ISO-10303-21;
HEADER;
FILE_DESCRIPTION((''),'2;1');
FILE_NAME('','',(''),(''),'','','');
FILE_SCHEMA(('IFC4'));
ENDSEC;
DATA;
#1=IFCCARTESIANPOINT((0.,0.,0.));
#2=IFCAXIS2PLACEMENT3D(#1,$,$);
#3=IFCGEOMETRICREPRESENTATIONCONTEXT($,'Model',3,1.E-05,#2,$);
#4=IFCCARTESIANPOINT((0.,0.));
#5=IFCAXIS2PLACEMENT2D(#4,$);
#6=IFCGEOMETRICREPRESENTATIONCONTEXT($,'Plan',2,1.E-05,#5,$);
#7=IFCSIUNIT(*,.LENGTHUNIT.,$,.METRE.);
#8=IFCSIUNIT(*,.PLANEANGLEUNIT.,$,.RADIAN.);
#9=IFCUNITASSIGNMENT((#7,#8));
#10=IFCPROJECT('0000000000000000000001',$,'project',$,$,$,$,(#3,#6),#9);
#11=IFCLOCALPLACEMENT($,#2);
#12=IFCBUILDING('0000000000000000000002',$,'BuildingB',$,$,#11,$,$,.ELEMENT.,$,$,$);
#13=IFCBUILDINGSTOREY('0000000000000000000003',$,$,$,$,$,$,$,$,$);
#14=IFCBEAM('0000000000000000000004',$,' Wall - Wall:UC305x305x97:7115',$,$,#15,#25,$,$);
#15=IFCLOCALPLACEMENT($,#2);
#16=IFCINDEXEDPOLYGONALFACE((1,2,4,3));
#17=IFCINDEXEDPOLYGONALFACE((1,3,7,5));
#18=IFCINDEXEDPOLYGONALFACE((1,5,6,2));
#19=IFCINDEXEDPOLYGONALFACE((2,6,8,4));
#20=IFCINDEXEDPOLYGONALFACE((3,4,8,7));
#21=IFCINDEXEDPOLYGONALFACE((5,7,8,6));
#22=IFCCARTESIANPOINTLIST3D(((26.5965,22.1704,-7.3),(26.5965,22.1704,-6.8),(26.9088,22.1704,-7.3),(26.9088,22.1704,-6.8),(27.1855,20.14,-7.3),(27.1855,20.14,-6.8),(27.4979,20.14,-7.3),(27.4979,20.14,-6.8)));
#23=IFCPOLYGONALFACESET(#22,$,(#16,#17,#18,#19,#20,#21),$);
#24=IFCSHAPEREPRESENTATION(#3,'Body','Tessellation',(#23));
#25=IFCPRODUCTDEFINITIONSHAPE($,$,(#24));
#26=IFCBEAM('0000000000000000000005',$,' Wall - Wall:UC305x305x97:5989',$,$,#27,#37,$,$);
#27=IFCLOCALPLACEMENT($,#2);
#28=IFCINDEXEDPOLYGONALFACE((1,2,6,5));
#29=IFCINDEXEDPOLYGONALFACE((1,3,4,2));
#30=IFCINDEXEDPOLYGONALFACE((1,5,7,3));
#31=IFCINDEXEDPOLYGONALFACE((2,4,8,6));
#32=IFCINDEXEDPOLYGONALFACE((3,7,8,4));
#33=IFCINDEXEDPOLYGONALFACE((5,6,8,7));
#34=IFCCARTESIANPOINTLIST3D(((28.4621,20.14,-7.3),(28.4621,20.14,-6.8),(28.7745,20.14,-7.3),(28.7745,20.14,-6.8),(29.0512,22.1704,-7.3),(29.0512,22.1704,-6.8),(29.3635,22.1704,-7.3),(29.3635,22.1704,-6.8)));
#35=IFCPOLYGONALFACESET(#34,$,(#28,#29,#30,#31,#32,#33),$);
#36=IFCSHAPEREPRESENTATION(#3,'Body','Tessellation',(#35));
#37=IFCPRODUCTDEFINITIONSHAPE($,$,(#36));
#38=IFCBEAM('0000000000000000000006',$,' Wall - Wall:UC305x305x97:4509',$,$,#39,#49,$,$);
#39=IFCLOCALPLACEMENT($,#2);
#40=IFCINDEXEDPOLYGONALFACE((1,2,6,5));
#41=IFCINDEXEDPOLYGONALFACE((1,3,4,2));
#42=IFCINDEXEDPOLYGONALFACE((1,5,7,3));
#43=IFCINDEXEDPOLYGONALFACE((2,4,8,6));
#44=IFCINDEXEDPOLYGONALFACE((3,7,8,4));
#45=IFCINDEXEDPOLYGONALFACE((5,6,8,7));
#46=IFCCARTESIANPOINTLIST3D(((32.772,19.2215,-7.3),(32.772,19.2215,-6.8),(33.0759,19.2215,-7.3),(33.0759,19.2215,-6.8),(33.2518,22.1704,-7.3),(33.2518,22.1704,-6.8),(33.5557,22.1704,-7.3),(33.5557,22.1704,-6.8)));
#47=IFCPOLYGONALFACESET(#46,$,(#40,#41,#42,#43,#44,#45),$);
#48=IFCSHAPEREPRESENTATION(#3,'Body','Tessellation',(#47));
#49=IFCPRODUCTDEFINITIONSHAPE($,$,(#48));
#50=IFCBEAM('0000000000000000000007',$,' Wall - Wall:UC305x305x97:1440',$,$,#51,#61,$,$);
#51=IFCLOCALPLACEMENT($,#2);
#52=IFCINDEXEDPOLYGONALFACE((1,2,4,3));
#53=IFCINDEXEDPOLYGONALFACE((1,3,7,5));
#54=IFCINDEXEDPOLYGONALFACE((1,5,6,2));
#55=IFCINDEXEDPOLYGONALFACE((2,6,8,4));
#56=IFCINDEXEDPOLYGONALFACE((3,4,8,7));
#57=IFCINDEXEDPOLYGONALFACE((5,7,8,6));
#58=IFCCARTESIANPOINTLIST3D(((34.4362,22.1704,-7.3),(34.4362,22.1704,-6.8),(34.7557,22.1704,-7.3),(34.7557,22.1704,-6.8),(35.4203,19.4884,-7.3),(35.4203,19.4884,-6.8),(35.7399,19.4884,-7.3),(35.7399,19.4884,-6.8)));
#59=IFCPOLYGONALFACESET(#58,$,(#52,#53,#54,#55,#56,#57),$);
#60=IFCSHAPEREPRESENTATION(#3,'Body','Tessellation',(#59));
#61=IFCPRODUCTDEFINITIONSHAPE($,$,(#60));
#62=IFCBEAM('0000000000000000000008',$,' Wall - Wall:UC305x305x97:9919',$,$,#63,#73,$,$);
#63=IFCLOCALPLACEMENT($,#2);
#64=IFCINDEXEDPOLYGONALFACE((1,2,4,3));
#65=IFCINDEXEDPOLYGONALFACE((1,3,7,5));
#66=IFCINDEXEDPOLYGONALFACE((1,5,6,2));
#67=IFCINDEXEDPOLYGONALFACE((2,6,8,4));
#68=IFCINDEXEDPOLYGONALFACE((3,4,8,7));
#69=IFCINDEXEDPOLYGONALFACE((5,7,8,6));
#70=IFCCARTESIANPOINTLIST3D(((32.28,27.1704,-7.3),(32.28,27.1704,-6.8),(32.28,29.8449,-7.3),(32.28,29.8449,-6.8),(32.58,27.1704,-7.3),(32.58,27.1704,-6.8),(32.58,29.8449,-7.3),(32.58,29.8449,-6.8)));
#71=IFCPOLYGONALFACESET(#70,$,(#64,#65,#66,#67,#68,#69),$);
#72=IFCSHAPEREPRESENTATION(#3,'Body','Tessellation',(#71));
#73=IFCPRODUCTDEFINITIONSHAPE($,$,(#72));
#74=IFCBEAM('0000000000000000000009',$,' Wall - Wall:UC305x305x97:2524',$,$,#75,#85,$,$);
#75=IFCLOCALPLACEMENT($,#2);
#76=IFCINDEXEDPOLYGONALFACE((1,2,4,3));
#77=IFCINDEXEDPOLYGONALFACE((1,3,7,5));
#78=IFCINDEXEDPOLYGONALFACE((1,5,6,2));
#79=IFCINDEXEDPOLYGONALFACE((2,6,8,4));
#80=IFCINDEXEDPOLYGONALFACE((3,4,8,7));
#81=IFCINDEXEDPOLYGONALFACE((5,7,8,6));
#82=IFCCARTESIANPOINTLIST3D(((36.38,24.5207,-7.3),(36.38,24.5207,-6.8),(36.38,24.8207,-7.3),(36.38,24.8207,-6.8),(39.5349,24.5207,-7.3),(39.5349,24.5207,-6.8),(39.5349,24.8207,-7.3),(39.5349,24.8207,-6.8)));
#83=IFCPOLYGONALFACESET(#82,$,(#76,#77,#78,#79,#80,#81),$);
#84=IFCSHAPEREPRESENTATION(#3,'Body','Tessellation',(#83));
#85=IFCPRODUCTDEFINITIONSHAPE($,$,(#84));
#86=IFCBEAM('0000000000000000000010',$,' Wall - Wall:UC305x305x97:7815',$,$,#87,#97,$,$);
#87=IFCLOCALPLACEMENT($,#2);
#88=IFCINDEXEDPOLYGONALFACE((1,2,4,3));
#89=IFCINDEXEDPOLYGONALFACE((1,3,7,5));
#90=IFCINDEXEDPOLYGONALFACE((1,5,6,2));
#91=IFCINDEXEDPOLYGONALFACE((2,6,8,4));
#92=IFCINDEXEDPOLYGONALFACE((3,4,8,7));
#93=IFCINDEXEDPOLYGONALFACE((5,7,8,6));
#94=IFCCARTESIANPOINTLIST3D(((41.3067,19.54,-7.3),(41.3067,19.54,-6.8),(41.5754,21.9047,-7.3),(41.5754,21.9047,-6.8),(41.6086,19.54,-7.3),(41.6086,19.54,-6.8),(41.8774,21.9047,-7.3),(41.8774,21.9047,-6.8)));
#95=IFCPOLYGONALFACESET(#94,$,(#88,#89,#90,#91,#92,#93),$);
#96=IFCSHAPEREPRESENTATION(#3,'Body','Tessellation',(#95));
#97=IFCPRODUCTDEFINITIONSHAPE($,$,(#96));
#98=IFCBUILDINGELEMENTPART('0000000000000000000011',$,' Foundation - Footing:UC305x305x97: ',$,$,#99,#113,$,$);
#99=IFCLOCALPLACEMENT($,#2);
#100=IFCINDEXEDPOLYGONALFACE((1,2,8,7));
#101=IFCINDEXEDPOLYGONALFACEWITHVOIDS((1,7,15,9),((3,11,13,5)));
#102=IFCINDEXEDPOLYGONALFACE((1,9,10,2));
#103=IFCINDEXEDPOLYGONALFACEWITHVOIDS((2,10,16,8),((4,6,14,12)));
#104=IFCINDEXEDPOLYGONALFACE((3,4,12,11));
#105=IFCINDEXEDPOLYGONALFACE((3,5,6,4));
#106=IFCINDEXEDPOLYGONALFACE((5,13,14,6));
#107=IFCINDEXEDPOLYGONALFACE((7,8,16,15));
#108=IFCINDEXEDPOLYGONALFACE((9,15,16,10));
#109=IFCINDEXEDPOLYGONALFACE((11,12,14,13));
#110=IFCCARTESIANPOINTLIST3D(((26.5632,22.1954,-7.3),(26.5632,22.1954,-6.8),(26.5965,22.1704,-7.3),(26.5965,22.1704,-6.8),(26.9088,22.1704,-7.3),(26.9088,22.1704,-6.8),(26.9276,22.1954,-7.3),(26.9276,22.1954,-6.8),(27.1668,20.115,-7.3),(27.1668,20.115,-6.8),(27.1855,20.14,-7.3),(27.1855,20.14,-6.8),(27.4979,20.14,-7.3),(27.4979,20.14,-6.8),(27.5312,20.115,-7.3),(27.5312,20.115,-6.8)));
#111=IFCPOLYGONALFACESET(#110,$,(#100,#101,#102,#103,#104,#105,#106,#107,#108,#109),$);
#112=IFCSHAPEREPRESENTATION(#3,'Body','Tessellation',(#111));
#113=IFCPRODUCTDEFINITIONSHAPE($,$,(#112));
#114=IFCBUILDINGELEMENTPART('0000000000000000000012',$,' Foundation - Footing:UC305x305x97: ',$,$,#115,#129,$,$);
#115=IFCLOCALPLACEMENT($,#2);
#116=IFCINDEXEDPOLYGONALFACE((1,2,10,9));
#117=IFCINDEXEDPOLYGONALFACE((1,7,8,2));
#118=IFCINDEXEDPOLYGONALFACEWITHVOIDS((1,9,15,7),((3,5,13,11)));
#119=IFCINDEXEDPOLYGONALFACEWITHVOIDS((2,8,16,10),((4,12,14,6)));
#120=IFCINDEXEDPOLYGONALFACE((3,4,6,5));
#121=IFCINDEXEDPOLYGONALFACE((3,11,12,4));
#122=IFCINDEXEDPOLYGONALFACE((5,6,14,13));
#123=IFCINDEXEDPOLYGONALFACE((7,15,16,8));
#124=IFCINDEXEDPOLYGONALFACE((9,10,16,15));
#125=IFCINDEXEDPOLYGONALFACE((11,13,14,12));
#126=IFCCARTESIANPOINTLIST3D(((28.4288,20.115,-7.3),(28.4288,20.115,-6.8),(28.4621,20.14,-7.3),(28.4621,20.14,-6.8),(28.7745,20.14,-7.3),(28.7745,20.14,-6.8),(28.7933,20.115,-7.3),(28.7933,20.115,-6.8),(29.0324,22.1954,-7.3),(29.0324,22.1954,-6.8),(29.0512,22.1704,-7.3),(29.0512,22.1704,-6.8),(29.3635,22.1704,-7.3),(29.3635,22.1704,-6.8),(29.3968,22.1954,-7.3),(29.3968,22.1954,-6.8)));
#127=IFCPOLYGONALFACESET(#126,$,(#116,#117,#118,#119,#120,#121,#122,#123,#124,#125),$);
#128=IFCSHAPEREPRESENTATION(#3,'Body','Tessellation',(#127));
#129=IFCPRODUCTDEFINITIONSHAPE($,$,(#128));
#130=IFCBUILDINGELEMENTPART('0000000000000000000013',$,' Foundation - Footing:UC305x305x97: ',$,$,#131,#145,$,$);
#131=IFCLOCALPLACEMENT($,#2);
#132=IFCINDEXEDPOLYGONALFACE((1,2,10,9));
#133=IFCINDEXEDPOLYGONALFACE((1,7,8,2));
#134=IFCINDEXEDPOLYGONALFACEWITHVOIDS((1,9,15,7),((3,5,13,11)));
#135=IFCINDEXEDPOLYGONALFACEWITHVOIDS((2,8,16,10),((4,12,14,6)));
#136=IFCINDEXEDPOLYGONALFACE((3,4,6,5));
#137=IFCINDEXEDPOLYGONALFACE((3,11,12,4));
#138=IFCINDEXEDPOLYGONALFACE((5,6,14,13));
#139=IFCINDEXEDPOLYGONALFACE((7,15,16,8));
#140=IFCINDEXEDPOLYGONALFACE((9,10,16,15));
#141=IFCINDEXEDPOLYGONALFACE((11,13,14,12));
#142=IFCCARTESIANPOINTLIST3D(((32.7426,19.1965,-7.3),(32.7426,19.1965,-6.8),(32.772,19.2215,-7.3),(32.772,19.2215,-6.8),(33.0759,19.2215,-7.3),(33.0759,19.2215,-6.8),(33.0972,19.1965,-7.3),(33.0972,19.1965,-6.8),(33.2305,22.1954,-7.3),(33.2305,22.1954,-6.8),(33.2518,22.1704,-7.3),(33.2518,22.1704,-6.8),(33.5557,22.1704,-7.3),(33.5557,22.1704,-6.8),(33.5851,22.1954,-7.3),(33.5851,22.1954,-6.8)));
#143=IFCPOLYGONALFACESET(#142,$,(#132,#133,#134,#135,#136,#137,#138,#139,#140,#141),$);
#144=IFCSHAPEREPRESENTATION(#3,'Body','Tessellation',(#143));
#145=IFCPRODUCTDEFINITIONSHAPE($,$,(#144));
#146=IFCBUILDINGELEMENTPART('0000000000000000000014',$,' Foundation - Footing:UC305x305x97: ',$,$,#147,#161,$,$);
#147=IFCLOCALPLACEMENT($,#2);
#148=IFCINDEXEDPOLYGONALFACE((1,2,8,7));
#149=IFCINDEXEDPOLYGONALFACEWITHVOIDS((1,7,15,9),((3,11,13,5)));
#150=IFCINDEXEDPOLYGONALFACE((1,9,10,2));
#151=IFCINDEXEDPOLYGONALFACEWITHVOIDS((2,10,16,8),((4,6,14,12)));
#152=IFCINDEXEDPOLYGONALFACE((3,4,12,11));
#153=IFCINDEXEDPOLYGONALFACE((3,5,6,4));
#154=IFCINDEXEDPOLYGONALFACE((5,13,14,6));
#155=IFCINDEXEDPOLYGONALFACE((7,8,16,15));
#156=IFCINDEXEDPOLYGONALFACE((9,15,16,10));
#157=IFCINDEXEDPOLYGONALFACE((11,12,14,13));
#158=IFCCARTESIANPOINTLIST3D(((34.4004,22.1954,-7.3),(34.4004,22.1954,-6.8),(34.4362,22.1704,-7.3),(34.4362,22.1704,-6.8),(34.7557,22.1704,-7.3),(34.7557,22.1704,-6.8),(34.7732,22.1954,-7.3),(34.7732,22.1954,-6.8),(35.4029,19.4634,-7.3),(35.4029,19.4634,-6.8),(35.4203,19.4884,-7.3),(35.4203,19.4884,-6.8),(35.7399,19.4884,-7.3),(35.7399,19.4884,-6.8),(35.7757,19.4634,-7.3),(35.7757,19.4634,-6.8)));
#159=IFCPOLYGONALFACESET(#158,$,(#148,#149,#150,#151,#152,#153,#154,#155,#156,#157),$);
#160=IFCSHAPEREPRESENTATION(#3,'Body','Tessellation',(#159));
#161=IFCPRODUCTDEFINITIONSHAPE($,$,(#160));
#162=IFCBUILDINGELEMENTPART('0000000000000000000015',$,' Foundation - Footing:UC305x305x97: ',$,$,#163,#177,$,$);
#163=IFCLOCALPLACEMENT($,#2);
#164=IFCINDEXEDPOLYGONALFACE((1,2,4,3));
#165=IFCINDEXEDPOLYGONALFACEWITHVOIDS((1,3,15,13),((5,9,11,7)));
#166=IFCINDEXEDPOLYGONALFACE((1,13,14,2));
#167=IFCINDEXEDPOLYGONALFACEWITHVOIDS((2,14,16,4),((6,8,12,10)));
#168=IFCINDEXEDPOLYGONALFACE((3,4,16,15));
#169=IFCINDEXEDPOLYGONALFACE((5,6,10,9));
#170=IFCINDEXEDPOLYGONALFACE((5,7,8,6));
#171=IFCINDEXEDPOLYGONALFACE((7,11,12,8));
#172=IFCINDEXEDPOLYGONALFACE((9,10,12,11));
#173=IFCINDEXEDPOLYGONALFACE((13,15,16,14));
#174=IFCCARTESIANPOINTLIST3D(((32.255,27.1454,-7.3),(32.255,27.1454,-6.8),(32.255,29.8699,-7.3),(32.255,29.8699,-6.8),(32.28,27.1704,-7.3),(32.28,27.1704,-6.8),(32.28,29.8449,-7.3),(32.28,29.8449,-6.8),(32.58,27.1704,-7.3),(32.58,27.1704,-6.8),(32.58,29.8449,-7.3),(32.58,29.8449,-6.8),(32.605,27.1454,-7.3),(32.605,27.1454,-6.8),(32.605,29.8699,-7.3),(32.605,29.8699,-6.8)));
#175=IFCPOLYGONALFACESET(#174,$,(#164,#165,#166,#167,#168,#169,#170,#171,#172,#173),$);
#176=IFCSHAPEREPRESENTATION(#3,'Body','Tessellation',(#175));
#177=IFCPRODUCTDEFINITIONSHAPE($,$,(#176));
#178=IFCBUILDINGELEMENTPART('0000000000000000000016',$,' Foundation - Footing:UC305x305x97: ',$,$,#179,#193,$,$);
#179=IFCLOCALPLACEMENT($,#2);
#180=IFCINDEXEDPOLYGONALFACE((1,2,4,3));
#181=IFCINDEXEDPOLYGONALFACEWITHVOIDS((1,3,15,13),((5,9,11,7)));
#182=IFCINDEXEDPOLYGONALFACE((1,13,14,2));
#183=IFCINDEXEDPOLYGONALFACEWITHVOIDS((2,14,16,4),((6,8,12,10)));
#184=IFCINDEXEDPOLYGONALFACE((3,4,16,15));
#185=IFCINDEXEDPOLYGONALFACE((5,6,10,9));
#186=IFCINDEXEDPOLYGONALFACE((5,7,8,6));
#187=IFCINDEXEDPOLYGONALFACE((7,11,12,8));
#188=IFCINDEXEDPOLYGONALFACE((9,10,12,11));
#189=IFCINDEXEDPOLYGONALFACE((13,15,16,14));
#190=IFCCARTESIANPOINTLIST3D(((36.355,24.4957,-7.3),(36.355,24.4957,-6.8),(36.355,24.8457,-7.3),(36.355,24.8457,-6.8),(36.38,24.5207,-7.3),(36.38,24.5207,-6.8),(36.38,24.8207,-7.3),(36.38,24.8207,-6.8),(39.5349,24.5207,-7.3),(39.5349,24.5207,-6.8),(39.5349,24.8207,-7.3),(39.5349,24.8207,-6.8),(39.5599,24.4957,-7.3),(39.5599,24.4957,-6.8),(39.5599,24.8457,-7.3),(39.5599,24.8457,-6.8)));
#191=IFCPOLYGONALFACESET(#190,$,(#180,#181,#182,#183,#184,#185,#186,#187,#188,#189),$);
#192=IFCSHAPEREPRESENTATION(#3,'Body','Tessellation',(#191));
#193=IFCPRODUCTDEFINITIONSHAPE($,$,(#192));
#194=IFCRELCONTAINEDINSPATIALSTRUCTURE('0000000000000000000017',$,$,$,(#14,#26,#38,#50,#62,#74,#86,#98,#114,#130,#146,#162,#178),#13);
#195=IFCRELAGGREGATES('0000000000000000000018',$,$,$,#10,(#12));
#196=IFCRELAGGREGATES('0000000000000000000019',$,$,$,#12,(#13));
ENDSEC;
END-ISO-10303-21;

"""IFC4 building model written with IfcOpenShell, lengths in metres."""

from ifc_helpers import new_model, si_unit, origin, origin_2d, place, context, project, spatial, polyline, outline, extrude, element, save


model = new_model("IFC4")

# Units and contexts
model_context = context("Model", 3, precision=1e-05, world=origin())
plan_context = context("Plan", 2, precision=1e-05, world=origin_2d())
ifc_project = project(units=[si_unit("LENGTHUNIT", "METRE"), si_unit("PLANEANGLEUNIT", "RADIAN")], contexts=[model_context, plan_context])

# Building, storey
building_placement = place(None, origin())
building = spatial("IfcBuilding", under=ifc_project, at=building_placement, Name="BuildingB", CompositionType="ELEMENT")
storey = spatial("IfcBuildingStorey", under=building)

# Beams
element("IfcBeam", 1, inside=storey, Name=" Wall - Wall:UC305x305x97:7115", context=model_context, shape_type="SweptSolid", body=[
    extrude(outline(polyline([(27.1855, 20.14, -7.3), (27.4979, 20.14, -7.3), (26.9088, 22.1704, -7.3), (26.5965, 22.1704, -7.3), (27.1855, 20.14, -7.3)])), None, (0.0, 0.0, 1.0), 0.5),
])
element("IfcBeam", 2, inside=storey, Name=" Wall - Wall:UC305x305x97:5989", context=model_context, shape_type="SweptSolid", body=[
    extrude(outline(polyline([(28.4621, 20.14, -7.3), (29.0512, 22.1704, -7.3), (29.3635, 22.1704, -7.3), (28.7745, 20.14, -7.3), (28.4621, 20.14, -7.3)])), None, (0.0, 0.0, 1.0), 0.5),
])
element("IfcBeam", 3, inside=storey, Name=" Wall - Wall:UC305x305x97:4509", context=model_context, shape_type="SweptSolid", body=[
    extrude(outline(polyline([(32.772, 19.2215, -7.3), (33.0759, 19.2215, -7.3), (33.5557, 22.1704, -7.3), (33.2518, 22.1704, -7.3), (32.772, 19.2215, -7.3)])), None, (0.0, 0.0, 1.0), 0.5),
])
element("IfcBeam", 4, inside=storey, Name=" Wall - Wall:UC305x305x97:1440", context=model_context, shape_type="SweptSolid", body=[
    extrude(outline(polyline([(35.4203, 19.4884, -7.3), (35.7399, 19.4884, -7.3), (34.7557, 22.1704, -7.3), (34.4362, 22.1704, -7.3), (35.4203, 19.4884, -7.3)])), None, (0.0, 0.0, 1.0), 0.5),
])
element("IfcBeam", 5, inside=storey, Name=" Wall - Wall:UC305x305x97:9919", context=model_context, shape_type="SweptSolid", body=[
    extrude(outline(polyline([(32.28, 27.1704, -7.3), (32.58, 27.1704, -7.3), (32.58, 29.8449, -7.3), (32.28, 29.8449, -7.3), (32.28, 27.1704, -7.3)])), None, (0.0, 0.0, 1.0), 0.5),
])
element("IfcBeam", 6, inside=storey, Name=" Wall - Wall:UC305x305x97:2524", context=model_context, shape_type="SweptSolid", body=[
    extrude(outline(polyline([(36.38, 24.5207, -7.3), (36.38, 24.8207, -7.3), (39.5349, 24.8207, -7.3), (39.5349, 24.5207, -7.3), (36.38, 24.5207, -7.3)])), None, (0.0, 0.0, 1.0), 0.5),
])
element("IfcBeam", 7, inside=storey, Name=" Wall - Wall:UC305x305x97:7815", context=model_context, shape_type="SweptSolid", body=[
    extrude(outline(polyline([(41.3067, 19.54, -7.3), (41.6086, 19.54, -7.3), (41.8774, 21.9047, -7.3), (41.5754, 21.9047, -7.3), (41.3067, 19.54, -7.3)])), None, (0.0, 0.0, 1.0), 0.5),
])

# Building element parts, openings
building_element_part_1 = element("IfcBuildingElementPart", 8, inside=storey, Name=" Foundation - Footing:UC305x305x97: ", context=model_context, shape_type="SweptSolid", body=[
    extrude(outline(polyline([(27.1668, 20.115, -7.3), (27.5312, 20.115, -7.3), (26.9276, 22.1954, -7.3), (26.5632, 22.1954, -7.3), (27.1668, 20.115, -7.3)])), None, (0.0, 0.0, 1.0), 0.5),
])
element("IfcOpeningElement", 9, inside=storey, cuts=building_element_part_1, context=model_context, shape_type="SweptSolid", body=[
    extrude(outline(polyline([(27.1855, 20.14, -7.3), (27.4979, 20.14, -7.3), (26.9088, 22.1704, -7.3), (26.5965, 22.1704, -7.3), (27.1855, 20.14, -7.3)])), None, (0.0, 0.0, 1.0), 0.5),
])
building_element_part_2 = element("IfcBuildingElementPart", 10, inside=storey, Name=" Foundation - Footing:UC305x305x97: ", context=model_context, shape_type="SweptSolid", body=[
    extrude(outline(polyline([(28.4288, 20.115, -7.3), (29.0324, 22.1954, -7.3), (29.3968, 22.1954, -7.3), (28.7933, 20.115, -7.3), (28.4288, 20.115, -7.3)])), None, (0.0, 0.0, 1.0), 0.5),
])
element("IfcOpeningElement", 11, inside=storey, cuts=building_element_part_2, context=model_context, shape_type="SweptSolid", body=[
    extrude(outline(polyline([(28.4621, 20.14, -7.3), (29.0512, 22.1704, -7.3), (29.3635, 22.1704, -7.3), (28.7745, 20.14, -7.3), (28.4621, 20.14, -7.3)])), None, (0.0, 0.0, 1.0), 0.5),
])
building_element_part_3 = element("IfcBuildingElementPart", 12, inside=storey, Name=" Foundation - Footing:UC305x305x97: ", context=model_context, shape_type="SweptSolid", body=[
    extrude(outline(polyline([(32.7426, 19.1965, -7.3), (33.0972, 19.1965, -7.3), (33.5851, 22.1954, -7.3), (33.2305, 22.1954, -7.3), (32.7426, 19.1965, -7.3)])), None, (0.0, 0.0, 1.0), 0.5),
])
element("IfcOpeningElement", 13, inside=storey, cuts=building_element_part_3, context=model_context, shape_type="SweptSolid", body=[
    extrude(outline(polyline([(32.772, 19.2215, -7.3), (33.0759, 19.2215, -7.3), (33.5557, 22.1704, -7.3), (33.2518, 22.1704, -7.3), (32.772, 19.2215, -7.3)])), None, (0.0, 0.0, 1.0), 0.5),
])
building_element_part_4 = element("IfcBuildingElementPart", 14, inside=storey, Name=" Foundation - Footing:UC305x305x97: ", context=model_context, shape_type="SweptSolid", body=[
    extrude(outline(polyline([(35.4029, 19.4634, -7.3), (35.7757, 19.4634, -7.3), (34.7732, 22.1954, -7.3), (34.4004, 22.1954, -7.3), (35.4029, 19.4634, -7.3)])), None, (0.0, 0.0, 1.0), 0.5),
])
element("IfcOpeningElement", 15, inside=storey, cuts=building_element_part_4, context=model_context, shape_type="SweptSolid", body=[
    extrude(outline(polyline([(35.4203, 19.4884, -7.3), (35.7399, 19.4884, -7.3), (34.7557, 22.1704, -7.3), (34.4362, 22.1704, -7.3), (35.4203, 19.4884, -7.3)])), None, (0.0, 0.0, 1.0), 0.5),
])
building_element_part_5 = element("IfcBuildingElementPart", 16, inside=storey, Name=" Foundation - Footing:UC305x305x97: ", context=model_context, shape_type="SweptSolid", body=[
    extrude(outline(polyline([(32.255, 27.1454, -7.3), (32.605, 27.1454, -7.3), (32.605, 29.8699, -7.3), (32.255, 29.8699, -7.3), (32.255, 27.1454, -7.3)])), None, (0.0, 0.0, 1.0), 0.5),
])
element("IfcOpeningElement", 17, inside=storey, cuts=building_element_part_5, context=model_context, shape_type="SweptSolid", body=[
    extrude(outline(polyline([(32.28, 27.1704, -7.3), (32.58, 27.1704, -7.3), (32.58, 29.8449, -7.3), (32.28, 29.8449, -7.3), (32.28, 27.1704, -7.3)])), None, (0.0, 0.0, 1.0), 0.5),
])
building_element_part_6 = element("IfcBuildingElementPart", 18, inside=storey, Name=" Foundation - Footing:UC305x305x97: ", context=model_context, shape_type="SweptSolid", body=[
    extrude(outline(polyline([(36.355, 24.4957, -7.3), (36.355, 24.8457, -7.3), (39.5599, 24.8457, -7.3), (39.5599, 24.4957, -7.3), (36.355, 24.4957, -7.3)])), None, (0.0, 0.0, 1.0), 0.5),
])
element("IfcOpeningElement", 19, inside=storey, cuts=building_element_part_6, context=model_context, shape_type="SweptSolid", body=[
    extrude(outline(polyline([(36.38, 24.5207, -7.3), (36.38, 24.8207, -7.3), (39.5349, 24.8207, -7.3), (39.5349, 24.5207, -7.3), (36.38, 24.5207, -7.3)])), None, (0.0, 0.0, 1.0), 0.5),
])

save(model, "model.ifc")
